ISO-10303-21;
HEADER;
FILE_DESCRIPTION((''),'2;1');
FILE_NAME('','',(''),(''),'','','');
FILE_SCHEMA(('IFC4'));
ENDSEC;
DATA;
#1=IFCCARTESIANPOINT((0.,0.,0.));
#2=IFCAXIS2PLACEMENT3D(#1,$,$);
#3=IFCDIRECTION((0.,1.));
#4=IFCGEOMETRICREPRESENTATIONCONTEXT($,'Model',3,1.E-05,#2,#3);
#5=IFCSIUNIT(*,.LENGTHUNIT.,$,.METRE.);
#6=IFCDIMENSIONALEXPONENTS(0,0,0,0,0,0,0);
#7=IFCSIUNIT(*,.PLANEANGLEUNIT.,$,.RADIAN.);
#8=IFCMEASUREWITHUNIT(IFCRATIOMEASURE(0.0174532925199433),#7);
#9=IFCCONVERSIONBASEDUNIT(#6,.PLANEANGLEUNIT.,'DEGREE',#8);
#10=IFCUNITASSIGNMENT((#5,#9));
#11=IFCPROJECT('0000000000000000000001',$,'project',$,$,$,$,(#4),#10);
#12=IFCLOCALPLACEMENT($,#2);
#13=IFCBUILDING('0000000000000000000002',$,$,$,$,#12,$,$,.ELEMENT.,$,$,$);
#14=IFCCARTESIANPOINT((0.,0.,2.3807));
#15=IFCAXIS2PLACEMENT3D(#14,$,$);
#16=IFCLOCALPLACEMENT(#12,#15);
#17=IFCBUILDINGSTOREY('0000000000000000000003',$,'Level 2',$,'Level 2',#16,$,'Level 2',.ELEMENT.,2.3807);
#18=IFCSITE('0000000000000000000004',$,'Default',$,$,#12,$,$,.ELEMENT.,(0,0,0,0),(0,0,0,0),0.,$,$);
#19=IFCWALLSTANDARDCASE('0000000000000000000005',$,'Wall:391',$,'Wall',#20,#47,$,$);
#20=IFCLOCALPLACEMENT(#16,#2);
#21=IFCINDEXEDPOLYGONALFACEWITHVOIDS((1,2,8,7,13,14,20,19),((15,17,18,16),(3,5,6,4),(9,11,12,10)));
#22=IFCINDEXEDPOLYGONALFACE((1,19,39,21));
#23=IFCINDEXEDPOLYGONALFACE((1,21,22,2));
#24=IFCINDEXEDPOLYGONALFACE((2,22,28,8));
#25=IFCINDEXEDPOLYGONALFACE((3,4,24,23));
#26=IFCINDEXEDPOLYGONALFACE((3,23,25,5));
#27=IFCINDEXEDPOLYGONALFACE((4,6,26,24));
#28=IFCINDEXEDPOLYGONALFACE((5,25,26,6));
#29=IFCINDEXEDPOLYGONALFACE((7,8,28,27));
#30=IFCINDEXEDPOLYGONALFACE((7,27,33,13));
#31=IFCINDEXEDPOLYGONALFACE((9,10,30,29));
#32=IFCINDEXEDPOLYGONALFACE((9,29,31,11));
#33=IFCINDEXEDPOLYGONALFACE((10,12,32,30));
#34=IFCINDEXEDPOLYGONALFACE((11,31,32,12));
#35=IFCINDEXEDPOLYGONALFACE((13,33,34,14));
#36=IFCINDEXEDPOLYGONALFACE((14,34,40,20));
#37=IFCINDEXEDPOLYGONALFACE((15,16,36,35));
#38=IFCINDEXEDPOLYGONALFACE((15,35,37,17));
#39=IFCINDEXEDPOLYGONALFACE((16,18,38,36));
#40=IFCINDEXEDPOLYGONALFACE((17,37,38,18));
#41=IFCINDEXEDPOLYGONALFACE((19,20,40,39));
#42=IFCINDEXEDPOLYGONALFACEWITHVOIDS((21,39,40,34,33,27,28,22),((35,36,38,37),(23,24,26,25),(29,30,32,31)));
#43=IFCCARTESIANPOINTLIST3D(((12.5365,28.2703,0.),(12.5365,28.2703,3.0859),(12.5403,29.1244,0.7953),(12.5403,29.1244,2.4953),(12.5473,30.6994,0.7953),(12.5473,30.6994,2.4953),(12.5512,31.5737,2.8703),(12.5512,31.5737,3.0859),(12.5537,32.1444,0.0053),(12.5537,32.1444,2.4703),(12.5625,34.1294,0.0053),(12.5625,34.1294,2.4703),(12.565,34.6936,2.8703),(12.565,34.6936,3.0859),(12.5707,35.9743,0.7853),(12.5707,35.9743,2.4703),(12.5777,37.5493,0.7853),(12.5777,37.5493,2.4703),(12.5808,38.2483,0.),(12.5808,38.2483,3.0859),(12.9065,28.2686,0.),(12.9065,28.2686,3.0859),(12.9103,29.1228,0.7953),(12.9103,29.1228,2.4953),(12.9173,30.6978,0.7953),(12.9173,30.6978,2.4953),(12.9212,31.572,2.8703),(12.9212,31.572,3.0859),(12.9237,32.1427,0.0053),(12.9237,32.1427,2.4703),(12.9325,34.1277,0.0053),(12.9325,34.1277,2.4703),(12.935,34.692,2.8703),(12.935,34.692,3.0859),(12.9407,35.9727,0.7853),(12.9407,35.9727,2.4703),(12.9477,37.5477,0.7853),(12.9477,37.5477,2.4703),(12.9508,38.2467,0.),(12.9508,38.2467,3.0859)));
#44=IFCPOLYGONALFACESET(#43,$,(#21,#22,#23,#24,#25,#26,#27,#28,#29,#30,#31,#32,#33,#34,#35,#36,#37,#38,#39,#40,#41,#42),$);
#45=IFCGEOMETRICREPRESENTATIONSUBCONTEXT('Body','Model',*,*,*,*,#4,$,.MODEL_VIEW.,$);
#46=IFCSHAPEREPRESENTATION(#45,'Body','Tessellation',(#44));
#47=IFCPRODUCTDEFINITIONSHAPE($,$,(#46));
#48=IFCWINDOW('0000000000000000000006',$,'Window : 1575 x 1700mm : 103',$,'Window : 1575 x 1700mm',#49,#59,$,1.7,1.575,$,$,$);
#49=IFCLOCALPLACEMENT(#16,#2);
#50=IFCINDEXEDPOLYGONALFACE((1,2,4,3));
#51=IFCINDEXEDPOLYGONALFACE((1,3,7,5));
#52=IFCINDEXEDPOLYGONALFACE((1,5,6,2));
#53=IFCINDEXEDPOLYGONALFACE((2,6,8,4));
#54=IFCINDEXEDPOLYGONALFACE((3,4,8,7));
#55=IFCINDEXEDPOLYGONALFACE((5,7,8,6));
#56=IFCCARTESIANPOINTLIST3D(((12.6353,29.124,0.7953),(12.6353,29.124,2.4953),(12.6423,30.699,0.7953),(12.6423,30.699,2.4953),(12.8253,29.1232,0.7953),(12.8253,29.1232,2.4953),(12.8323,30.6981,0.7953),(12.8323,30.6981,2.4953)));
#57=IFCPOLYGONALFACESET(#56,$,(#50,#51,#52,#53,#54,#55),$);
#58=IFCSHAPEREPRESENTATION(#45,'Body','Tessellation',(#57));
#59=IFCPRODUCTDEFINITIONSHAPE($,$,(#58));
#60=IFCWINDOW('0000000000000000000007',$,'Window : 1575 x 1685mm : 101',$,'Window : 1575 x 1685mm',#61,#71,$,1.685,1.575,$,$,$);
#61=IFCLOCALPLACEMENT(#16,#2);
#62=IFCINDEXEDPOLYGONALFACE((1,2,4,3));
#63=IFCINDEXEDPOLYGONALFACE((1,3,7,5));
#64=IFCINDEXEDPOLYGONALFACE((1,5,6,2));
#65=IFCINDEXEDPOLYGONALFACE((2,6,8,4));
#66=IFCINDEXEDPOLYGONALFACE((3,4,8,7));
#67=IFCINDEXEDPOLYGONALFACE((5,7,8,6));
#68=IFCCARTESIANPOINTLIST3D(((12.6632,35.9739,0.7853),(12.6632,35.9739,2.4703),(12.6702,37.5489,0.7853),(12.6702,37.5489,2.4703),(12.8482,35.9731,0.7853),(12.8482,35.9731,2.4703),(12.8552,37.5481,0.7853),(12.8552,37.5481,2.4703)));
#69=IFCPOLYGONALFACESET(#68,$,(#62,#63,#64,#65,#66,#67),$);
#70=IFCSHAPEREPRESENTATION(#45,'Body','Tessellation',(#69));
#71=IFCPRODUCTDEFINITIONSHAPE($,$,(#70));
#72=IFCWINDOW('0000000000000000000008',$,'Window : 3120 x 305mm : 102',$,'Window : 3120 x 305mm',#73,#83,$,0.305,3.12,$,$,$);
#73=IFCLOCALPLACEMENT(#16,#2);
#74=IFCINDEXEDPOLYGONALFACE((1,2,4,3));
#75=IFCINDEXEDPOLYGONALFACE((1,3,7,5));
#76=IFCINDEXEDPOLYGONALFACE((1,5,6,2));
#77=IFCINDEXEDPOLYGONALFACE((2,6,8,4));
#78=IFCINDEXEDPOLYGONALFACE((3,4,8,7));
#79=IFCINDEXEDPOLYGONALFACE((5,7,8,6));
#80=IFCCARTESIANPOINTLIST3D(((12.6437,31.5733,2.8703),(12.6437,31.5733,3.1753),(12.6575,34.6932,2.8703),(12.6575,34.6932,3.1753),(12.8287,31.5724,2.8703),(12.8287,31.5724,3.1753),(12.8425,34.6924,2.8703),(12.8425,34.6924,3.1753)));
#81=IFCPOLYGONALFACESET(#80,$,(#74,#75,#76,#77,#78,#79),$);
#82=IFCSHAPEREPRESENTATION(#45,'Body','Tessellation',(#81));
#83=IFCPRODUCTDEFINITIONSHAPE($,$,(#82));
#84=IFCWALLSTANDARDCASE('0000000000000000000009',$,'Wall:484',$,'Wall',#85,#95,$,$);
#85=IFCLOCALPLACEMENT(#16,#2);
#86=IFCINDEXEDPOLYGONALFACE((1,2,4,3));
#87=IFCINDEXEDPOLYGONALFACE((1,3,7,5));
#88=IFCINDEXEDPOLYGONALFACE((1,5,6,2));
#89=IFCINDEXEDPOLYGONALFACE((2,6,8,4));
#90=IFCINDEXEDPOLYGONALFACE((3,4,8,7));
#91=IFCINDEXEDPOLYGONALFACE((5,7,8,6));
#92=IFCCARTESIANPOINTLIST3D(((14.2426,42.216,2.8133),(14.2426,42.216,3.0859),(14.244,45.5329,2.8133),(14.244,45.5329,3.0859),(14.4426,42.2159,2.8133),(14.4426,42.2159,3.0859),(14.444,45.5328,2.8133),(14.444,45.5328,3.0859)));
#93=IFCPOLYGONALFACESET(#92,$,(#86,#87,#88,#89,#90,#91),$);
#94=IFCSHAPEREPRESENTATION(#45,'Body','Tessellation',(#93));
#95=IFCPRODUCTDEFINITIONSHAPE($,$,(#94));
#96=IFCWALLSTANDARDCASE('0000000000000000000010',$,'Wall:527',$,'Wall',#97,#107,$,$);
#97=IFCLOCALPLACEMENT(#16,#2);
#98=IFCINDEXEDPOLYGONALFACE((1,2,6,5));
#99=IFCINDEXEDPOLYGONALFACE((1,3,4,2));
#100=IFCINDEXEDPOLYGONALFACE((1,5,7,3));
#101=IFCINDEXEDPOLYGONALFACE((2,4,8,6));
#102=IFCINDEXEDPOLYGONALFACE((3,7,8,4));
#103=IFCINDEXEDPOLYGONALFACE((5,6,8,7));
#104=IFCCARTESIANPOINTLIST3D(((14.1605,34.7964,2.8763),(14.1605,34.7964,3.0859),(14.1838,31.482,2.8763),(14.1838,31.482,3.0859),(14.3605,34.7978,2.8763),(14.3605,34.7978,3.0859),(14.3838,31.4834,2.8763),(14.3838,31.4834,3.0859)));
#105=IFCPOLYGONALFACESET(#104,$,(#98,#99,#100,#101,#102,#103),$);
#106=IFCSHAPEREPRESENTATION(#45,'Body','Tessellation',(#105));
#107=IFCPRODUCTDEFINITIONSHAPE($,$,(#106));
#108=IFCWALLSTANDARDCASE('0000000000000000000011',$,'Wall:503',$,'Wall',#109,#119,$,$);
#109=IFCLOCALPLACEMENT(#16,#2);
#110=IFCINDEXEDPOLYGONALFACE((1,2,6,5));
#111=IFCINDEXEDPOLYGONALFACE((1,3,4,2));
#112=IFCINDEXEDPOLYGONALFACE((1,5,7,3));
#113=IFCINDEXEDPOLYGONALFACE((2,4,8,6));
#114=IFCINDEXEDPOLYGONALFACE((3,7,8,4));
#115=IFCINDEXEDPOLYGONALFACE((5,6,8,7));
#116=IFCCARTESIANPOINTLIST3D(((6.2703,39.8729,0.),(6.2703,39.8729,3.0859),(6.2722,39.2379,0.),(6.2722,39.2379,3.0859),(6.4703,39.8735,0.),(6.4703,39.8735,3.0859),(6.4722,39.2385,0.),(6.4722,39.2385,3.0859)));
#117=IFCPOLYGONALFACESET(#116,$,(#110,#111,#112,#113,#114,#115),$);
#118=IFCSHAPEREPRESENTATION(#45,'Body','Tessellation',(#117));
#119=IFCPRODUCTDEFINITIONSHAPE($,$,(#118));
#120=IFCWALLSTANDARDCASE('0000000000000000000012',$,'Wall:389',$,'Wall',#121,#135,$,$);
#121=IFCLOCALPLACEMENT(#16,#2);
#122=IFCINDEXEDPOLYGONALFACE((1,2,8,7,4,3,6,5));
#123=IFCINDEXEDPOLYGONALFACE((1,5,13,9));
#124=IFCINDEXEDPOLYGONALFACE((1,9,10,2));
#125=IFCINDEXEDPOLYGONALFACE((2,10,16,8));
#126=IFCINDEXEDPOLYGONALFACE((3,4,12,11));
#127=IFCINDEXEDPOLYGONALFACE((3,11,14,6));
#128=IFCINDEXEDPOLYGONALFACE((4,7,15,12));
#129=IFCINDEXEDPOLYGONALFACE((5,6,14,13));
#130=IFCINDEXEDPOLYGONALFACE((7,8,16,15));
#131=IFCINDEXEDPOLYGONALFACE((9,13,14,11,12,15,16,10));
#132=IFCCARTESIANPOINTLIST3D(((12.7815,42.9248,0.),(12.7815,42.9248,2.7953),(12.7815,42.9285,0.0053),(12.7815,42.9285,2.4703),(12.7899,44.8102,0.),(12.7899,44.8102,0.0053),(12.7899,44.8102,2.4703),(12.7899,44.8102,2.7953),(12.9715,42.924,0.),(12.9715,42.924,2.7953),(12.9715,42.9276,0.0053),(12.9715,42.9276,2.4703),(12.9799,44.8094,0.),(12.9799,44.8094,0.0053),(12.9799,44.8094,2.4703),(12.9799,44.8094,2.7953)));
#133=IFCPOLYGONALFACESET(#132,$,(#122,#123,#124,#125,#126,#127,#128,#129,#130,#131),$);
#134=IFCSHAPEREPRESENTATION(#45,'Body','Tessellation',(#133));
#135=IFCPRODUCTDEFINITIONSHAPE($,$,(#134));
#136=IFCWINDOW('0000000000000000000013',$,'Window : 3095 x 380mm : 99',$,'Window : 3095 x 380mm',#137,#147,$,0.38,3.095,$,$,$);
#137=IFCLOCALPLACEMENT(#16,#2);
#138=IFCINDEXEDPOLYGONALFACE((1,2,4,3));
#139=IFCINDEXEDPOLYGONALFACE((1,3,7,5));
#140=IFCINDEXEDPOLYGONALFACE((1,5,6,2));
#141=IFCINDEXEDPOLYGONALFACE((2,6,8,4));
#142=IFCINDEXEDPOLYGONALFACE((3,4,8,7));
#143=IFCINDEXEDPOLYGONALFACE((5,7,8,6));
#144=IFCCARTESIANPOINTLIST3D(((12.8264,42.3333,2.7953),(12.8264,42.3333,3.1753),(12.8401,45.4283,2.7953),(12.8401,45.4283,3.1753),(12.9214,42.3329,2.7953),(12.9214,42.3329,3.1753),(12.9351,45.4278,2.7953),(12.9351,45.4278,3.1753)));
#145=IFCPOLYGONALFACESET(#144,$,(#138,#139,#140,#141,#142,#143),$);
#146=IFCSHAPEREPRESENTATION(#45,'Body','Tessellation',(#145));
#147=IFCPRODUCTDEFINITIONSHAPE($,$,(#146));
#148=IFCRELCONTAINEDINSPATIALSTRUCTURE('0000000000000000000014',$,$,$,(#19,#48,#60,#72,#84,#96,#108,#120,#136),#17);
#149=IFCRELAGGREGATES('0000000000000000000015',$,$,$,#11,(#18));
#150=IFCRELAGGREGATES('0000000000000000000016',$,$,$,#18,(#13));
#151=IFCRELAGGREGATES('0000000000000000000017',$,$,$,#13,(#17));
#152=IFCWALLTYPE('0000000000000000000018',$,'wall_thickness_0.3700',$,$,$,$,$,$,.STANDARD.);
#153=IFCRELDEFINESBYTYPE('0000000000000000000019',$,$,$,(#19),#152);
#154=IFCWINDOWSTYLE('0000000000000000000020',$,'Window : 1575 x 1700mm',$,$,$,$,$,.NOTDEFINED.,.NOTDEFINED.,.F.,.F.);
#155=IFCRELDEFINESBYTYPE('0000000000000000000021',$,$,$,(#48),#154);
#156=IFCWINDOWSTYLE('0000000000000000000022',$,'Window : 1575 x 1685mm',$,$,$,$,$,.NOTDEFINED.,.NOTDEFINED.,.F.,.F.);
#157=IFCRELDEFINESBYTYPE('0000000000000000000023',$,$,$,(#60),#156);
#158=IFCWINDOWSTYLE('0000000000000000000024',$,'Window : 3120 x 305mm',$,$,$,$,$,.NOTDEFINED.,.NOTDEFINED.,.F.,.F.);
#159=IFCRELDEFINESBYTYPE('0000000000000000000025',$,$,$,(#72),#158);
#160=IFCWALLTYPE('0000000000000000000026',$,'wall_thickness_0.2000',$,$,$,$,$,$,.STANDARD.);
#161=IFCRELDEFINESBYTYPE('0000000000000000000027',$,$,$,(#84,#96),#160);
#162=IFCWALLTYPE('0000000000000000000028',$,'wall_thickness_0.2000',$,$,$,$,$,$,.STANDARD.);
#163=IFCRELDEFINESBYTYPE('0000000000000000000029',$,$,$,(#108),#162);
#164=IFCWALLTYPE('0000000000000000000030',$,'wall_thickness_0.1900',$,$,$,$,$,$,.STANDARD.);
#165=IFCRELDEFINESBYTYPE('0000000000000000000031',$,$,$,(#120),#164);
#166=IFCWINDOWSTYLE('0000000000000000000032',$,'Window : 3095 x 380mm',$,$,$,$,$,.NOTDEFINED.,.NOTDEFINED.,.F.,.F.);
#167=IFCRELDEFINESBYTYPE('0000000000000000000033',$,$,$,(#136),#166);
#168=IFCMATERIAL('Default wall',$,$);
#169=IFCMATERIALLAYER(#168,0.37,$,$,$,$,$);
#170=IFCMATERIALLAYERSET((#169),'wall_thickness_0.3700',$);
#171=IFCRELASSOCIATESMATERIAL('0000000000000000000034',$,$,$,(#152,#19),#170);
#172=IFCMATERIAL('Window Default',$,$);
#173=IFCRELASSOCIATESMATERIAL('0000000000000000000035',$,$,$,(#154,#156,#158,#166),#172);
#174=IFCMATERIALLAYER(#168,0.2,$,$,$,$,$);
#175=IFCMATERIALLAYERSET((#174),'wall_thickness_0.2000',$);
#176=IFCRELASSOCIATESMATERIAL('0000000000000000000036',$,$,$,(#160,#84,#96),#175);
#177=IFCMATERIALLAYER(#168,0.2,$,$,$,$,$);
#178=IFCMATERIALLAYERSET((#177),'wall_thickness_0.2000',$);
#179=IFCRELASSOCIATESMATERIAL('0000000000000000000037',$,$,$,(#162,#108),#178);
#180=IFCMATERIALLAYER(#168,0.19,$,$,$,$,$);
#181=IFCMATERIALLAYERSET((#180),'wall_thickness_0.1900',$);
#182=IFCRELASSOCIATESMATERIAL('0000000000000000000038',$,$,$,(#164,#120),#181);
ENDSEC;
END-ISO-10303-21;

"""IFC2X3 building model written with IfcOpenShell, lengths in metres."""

from ifc_helpers import new_model, entity, si_unit, converted_unit, direction, frame, frame_2d, origin, origin_2d_with_axis, place, context, subcontext, project, spatial, polyline, rectangle, outline, extrude, source, transform, mapped, material, layer, layer_set, layer_usage, type_object, type_shapes, element, fill, save


model = new_model("IFC2X3")

# Units and contexts
model_context = context("Model", 3, precision=1e-05, world=origin(), true_north=direction((0.0, 1.0)))
body_context = subcontext(model_context, "Body", "Model", "MODEL_VIEW")
ifc_project = project(units=[si_unit("LENGTHUNIT", "METRE"), converted_unit("PLANEANGLEUNIT", "DEGREE", entity("IfcRatioMeasure", 0.0174532925199433), si_unit("PLANEANGLEUNIT", "RADIAN"), dimensions=[0, 0, 0, 0, 0, 0, 0])], contexts=[model_context])

# Site, building, storey
placement_1 = place(None, origin())
site = spatial("IfcSite", under=ifc_project, at=placement_1, Name="Default", CompositionType="ELEMENT", RefLatitude=(0, 0, 0, 0), RefLongitude=(0, 0, 0, 0), RefElevation=0.0)
building = spatial("IfcBuilding", under=site, at=placement_1, CompositionType="ELEMENT")
storey_placement = place(placement_1, frame((0.0, 0.0, 2.3807)))
storey = spatial("IfcBuildingStorey", under=building, at=storey_placement, Name="Level 2", ObjectType="Level 2", LongName="Level 2", CompositionType="ELEMENT", Elevation=2.3807)

# Shared definitions
ifc_material_1 = material(Name="Default wall")
ifc_material_2 = material(Name="Window Default")

# Shared definitions
ifc_layer_1 = layer(ifc_material_1, 0.37)
ifc_layer_set_1 = layer_set([ifc_layer_1], Name="wall_thickness_0.3700")
ifc_layer_usage_1 = layer_usage(ifc_layer_set_1, "AXIS2", "POSITIVE", -0.185)
wall_type_1 = type_object("IfcWallType", Name="wall_thickness_0.3700", PredefinedType="STANDARD", material=ifc_layer_set_1)

# Wall, openings, windows
wall_1_placement = place(storey_placement, frame((12.7658, 38.2475, 0.0), z_axis=(0.0, 0.0, 1.0), x_axis=(-0.004434, -0.99999, 0.0)))
wall_1 = element("IfcWallStandardCase", 1, at=wall_1_placement, inside=storey, type_object=wall_type_1, material=ifc_layer_usage_1, Name="Wall:391", ObjectType="Wall", context=body_context, shape_type="SweptSolid", body=[
    extrude(outline(polyline([(9.9782, -0.185), (9.9782, 0.185), (0.0, 0.185), (0.0, -0.185), (9.9782, -0.185)])), origin(), (0.0, 0.0, 1.0), 3.0859),
])
opening_1_placement = place(wall_1_placement, frame((4.119, -0.185, 0.0053)))
element("IfcOpeningElement", 2, at=opening_1_placement, cuts=wall_1, ObjectType="Opening", context=body_context, shape_type="SweptSolid", body=[
    extrude(rectangle(XDim=1.985, YDim=2.465, at=frame_2d((1.2325, 0.9925), x_axis=(0.0, 1.0))), frame((0.0, 0.0, 0.0), z_axis=(0.0, 1.0, 0.0), x_axis=(0.0, 0.0, 1.0)), (0.0, 0.0, 1.0), 0.37),
])
opening_2_placement = place(wall_1_placement, frame((0.699, -0.185, 0.7853)))
opening_2 = element("IfcOpeningElement", 3, at=opening_2_placement, cuts=wall_1, ObjectType="Opening", context=body_context, shape_type="SweptSolid", body=[
    extrude(rectangle(XDim=1.575, YDim=1.685, at=frame_2d((0.8425, 0.7875), x_axis=(0.0, 1.0))), frame((0.0, 0.0, 0.0), z_axis=(0.0, 1.0, 0.0), x_axis=(0.0, 0.0, 1.0)), (0.0, 0.0, 1.0), 0.37),
])
opening_3_placement = place(wall_1_placement, frame((3.5547, -0.185, 2.8703)))
opening_3 = element("IfcOpeningElement", 4, at=opening_3_placement, cuts=wall_1, ObjectType="Opening", context=body_context, shape_type="SweptSolid", body=[
    extrude(rectangle(XDim=3.12, YDim=0.305, at=frame_2d((0.1525, 1.56), x_axis=(0.0, 1.0))), frame((0.0, 0.0, 0.0), z_axis=(0.0, 1.0, 0.0), x_axis=(0.0, 0.0, 1.0)), (0.0, 0.0, 1.0), 0.37),
])
opening_4_placement = place(wall_1_placement, frame((7.549, -0.185, 0.7953)))
opening_4 = element("IfcOpeningElement", 5, at=opening_4_placement, cuts=wall_1, ObjectType="Opening", context=body_context, shape_type="SweptSolid", body=[
    extrude(rectangle(XDim=1.575, YDim=1.7, at=frame_2d((0.85, 0.7875), x_axis=(0.0, 1.0))), frame((0.0, 0.0, 0.0), z_axis=(0.0, 1.0, 0.0), x_axis=(0.0, 0.0, 1.0)), (0.0, 0.0, 1.0), 0.37),
])
window_style_1 = type_object("IfcWindowStyle", Name="Window : 1575 x 1700mm", ConstructionType="NOTDEFINED", OperationType="NOTDEFINED", ParameterTakesPrecedence=False, Sizeable=False, material=ifc_material_2)
shared_shape_1 = source(origin(), body_context, "Body", "SweptSolid", [
    extrude(rectangle(XDim=0.19, YDim=1.575, at=origin_2d_with_axis()), frame((0.7875, 0.19, 0.0), z_axis=(0.0, 0.0, 1.0), x_axis=(0.0, 1.0, 0.0)), (0.0, 0.0, 1.0), 1.7),
])
type_shapes(window_style_1, [shared_shape_1])
window_1_placement = place(opening_4_placement, origin())
window_1 = element("IfcWindow", 6, at=window_1_placement, inside=storey, type_object=window_style_1, Name="Window : 1575 x 1700mm : 103", ObjectType="Window : 1575 x 1700mm", OverallHeight=1.7, OverallWidth=1.575, context=body_context, shape_type="MappedRepresentation", body=[
    mapped(shared_shape_1, transform((0.0, 0.0, 0.0), scale=1.0)),
])
fill(opening_4, window_1)
window_style_2 = type_object("IfcWindowStyle", Name="Window : 1575 x 1685mm", ConstructionType="NOTDEFINED", OperationType="NOTDEFINED", ParameterTakesPrecedence=False, Sizeable=False, material=ifc_material_2)
shared_shape_2 = source(origin(), body_context, "Body", "SweptSolid", [
    extrude(rectangle(XDim=0.185, YDim=1.575, at=origin_2d_with_axis()), frame((0.7875, 0.185, 0.0), z_axis=(0.0, 0.0, 1.0), x_axis=(0.0, 1.0, 0.0)), (0.0, 0.0, 1.0), 1.685),
])
type_shapes(window_style_2, [shared_shape_2])
window_2_placement = place(opening_2_placement, origin())
window_2 = element("IfcWindow", 7, at=window_2_placement, inside=storey, type_object=window_style_2, Name="Window : 1575 x 1685mm : 101", ObjectType="Window : 1575 x 1685mm", OverallHeight=1.685, OverallWidth=1.575, context=body_context, shape_type="MappedRepresentation", body=[
    mapped(shared_shape_2, transform((0.0, 0.0, 0.0), scale=1.0)),
])
fill(opening_2, window_2)
window_style_3 = type_object("IfcWindowStyle", Name="Window : 3120 x 305mm", ConstructionType="NOTDEFINED", OperationType="NOTDEFINED", ParameterTakesPrecedence=False, Sizeable=False, material=ifc_material_2)
shared_shape_3 = source(origin(), body_context, "Body", "SweptSolid", [
    extrude(rectangle(XDim=0.185, YDim=3.12, at=origin_2d_with_axis()), frame((1.56, 0.185, 0.0), z_axis=(0.0, 0.0, 1.0), x_axis=(0.0, 1.0, 0.0)), (0.0, 0.0, 1.0), 0.305),
])
type_shapes(window_style_3, [shared_shape_3])
window_3_placement = place(opening_3_placement, origin())
window_3 = element("IfcWindow", 8, at=window_3_placement, inside=storey, type_object=window_style_3, Name="Window : 3120 x 305mm : 102", ObjectType="Window : 3120 x 305mm", OverallHeight=0.305, OverallWidth=3.12, context=body_context, shape_type="MappedRepresentation", body=[
    mapped(shared_shape_3, transform((0.0, 0.0, 0.0), scale=1.0)),
])
fill(opening_3, window_3)

# Walls
ifc_layer_2 = layer(ifc_material_1, 0.2)
ifc_layer_set_2 = layer_set([ifc_layer_2], Name="wall_thickness_0.2000")
ifc_layer_usage_2 = layer_usage(ifc_layer_set_2, "AXIS2", "POSITIVE", -0.1)
wall_type_2 = type_object("IfcWallType", Name="wall_thickness_0.2000", PredefinedType="STANDARD", material=ifc_layer_set_2)
placement_2 = place(placement_1, frame((0.0, 0.0, 5.194)))
wall_2_placement = place(placement_2, frame((14.344, 45.5328, 0.0), z_axis=(0.0, 0.0, 1.0), x_axis=(-0.000428, -1.0, 0.0)))
element("IfcWallStandardCase", 9, at=wall_2_placement, inside=storey, type_object=wall_type_2, material=ifc_layer_usage_2, Name="Wall:484", ObjectType="Wall", context=body_context, shape_type="SweptSolid", body=[
    extrude(outline(polyline([(3.3169, -0.1), (3.3169, 0.1), (0.0, 0.1), (0.0, -0.1), (3.3169, -0.1)])), origin(), (0.0, 0.0, 1.0), 0.2726),
])
placement_3 = place(placement_1, frame((0.0, 0.0, 5.257)))
wall_3_placement = place(placement_3, frame((14.2605, 34.7971, 0.0), z_axis=(0.0, 0.0, 1.0), x_axis=(0.007042, -0.999975, 0.0)))
element("IfcWallStandardCase", 10, at=wall_3_placement, inside=storey, type_object=wall_type_2, material=ifc_layer_usage_2, Name="Wall:527", ObjectType="Wall", context=body_context, shape_type="SweptSolid", body=[
    extrude(outline(polyline([(3.3144, -0.1), (3.3144, 0.1), (0.0, 0.1), (0.0, -0.1), (3.3144, -0.1)])), origin(), (0.0, 0.0, 1.0), 0.2096),
])
ifc_layer_3 = layer(ifc_material_1, 0.2)
ifc_layer_set_3 = layer_set([ifc_layer_3], Name="wall_thickness_0.2000")
ifc_layer_usage_3 = layer_usage(ifc_layer_set_3, "AXIS2", "POSITIVE", -0.1)
wall_type_3 = type_object("IfcWallType", Name="wall_thickness_0.2000", PredefinedType="STANDARD", material=ifc_layer_set_3)
wall_4_placement = place(storey_placement, frame((6.3703, 39.8732, 0.0), z_axis=(0.0, 0.0, 1.0), x_axis=(0.002951, -0.999996, 0.0)))
element("IfcWallStandardCase", 11, at=wall_4_placement, inside=storey, type_object=wall_type_3, material=ifc_layer_usage_3, Name="Wall:503", ObjectType="Wall", context=body_context, shape_type="SweptSolid", body=[
    extrude(outline(polyline([(0.635, -0.1), (0.635, 0.1), (0.0, 0.1), (0.0, -0.1), (0.635, -0.1)])), origin(), (0.0, 0.0, 1.0), 3.0859),
])

# Wall, openings, window
ifc_layer_4 = layer(ifc_material_1, 0.19)
ifc_layer_set_4 = layer_set([ifc_layer_4], Name="wall_thickness_0.1900")
ifc_layer_usage_4 = layer_usage(ifc_layer_set_4, "AXIS2", "POSITIVE", -0.095)
wall_type_4 = type_object("IfcWallType", Name="wall_thickness_0.1900", PredefinedType="STANDARD", material=ifc_layer_set_4)
wall_5_placement = place(storey_placement, frame((12.8849, 44.8098, 0.0), z_axis=(0.0, 0.0, 1.0), x_axis=(-0.004435, -0.99999, 0.0)))
wall_5 = element("IfcWallStandardCase", 12, at=wall_5_placement, inside=storey, type_object=wall_type_4, material=ifc_layer_usage_4, Name="Wall:389", ObjectType="Wall", context=body_context, shape_type="SweptSolid", body=[
    extrude(outline(polyline([(1.8854, -0.095), (1.8854, 0.095), (0.0, 0.095), (0.0, -0.095), (1.8854, -0.095)])), origin(), (0.0, 0.0, 1.0), 3.0859),
])
opening_5_placement = place(wall_5_placement, frame((-0.1132, -0.095, 0.0053)))
element("IfcOpeningElement", 13, at=opening_5_placement, cuts=wall_5, ObjectType="Opening", context=body_context, shape_type="SweptSolid", body=[
    extrude(rectangle(XDim=1.995, YDim=2.465, at=frame_2d((1.2325, 0.9975), x_axis=(0.0, 1.0))), frame((0.0, 0.0, 0.0), z_axis=(0.0, 1.0, 0.0), x_axis=(0.0, 0.0, 1.0)), (0.0, 0.0, 1.0), 0.19),
])
opening_6_placement = place(wall_5_placement, frame((-0.6183, -0.095, 2.7953)))
opening_6 = element("IfcOpeningElement", 14, at=opening_6_placement, cuts=wall_5, ObjectType="Opening", context=body_context, shape_type="SweptSolid", body=[
    extrude(rectangle(XDim=3.095, YDim=0.38, at=frame_2d((0.19, 1.5475), x_axis=(0.0, 1.0))), frame((0.0, 0.0, 0.0), z_axis=(0.0, 1.0, 0.0), x_axis=(0.0, 0.0, 1.0)), (0.0, 0.0, 1.0), 0.19),
])
window_style_4 = type_object("IfcWindowStyle", Name="Window : 3095 x 380mm", ConstructionType="NOTDEFINED", OperationType="NOTDEFINED", ParameterTakesPrecedence=False, Sizeable=False, material=ifc_material_2)
shared_shape_4 = source(origin(), body_context, "Body", "SweptSolid", [
    extrude(rectangle(XDim=0.095, YDim=3.095, at=origin_2d_with_axis()), frame((1.5475, 0.095, 0.0), z_axis=(0.0, 0.0, 1.0), x_axis=(0.0, 1.0, 0.0)), (0.0, 0.0, 1.0), 0.38),
])
type_shapes(window_style_4, [shared_shape_4])
window_4_placement = place(opening_6_placement, origin())
window_4 = element("IfcWindow", 15, at=window_4_placement, inside=storey, type_object=window_style_4, Name="Window : 3095 x 380mm : 99", ObjectType="Window : 3095 x 380mm", OverallHeight=0.38, OverallWidth=3.095, context=body_context, shape_type="MappedRepresentation", body=[
    mapped(shared_shape_4, transform((0.0, 0.0, 0.0), scale=1.0)),
])
fill(opening_6, window_4)

save(model, "model.ifc")
